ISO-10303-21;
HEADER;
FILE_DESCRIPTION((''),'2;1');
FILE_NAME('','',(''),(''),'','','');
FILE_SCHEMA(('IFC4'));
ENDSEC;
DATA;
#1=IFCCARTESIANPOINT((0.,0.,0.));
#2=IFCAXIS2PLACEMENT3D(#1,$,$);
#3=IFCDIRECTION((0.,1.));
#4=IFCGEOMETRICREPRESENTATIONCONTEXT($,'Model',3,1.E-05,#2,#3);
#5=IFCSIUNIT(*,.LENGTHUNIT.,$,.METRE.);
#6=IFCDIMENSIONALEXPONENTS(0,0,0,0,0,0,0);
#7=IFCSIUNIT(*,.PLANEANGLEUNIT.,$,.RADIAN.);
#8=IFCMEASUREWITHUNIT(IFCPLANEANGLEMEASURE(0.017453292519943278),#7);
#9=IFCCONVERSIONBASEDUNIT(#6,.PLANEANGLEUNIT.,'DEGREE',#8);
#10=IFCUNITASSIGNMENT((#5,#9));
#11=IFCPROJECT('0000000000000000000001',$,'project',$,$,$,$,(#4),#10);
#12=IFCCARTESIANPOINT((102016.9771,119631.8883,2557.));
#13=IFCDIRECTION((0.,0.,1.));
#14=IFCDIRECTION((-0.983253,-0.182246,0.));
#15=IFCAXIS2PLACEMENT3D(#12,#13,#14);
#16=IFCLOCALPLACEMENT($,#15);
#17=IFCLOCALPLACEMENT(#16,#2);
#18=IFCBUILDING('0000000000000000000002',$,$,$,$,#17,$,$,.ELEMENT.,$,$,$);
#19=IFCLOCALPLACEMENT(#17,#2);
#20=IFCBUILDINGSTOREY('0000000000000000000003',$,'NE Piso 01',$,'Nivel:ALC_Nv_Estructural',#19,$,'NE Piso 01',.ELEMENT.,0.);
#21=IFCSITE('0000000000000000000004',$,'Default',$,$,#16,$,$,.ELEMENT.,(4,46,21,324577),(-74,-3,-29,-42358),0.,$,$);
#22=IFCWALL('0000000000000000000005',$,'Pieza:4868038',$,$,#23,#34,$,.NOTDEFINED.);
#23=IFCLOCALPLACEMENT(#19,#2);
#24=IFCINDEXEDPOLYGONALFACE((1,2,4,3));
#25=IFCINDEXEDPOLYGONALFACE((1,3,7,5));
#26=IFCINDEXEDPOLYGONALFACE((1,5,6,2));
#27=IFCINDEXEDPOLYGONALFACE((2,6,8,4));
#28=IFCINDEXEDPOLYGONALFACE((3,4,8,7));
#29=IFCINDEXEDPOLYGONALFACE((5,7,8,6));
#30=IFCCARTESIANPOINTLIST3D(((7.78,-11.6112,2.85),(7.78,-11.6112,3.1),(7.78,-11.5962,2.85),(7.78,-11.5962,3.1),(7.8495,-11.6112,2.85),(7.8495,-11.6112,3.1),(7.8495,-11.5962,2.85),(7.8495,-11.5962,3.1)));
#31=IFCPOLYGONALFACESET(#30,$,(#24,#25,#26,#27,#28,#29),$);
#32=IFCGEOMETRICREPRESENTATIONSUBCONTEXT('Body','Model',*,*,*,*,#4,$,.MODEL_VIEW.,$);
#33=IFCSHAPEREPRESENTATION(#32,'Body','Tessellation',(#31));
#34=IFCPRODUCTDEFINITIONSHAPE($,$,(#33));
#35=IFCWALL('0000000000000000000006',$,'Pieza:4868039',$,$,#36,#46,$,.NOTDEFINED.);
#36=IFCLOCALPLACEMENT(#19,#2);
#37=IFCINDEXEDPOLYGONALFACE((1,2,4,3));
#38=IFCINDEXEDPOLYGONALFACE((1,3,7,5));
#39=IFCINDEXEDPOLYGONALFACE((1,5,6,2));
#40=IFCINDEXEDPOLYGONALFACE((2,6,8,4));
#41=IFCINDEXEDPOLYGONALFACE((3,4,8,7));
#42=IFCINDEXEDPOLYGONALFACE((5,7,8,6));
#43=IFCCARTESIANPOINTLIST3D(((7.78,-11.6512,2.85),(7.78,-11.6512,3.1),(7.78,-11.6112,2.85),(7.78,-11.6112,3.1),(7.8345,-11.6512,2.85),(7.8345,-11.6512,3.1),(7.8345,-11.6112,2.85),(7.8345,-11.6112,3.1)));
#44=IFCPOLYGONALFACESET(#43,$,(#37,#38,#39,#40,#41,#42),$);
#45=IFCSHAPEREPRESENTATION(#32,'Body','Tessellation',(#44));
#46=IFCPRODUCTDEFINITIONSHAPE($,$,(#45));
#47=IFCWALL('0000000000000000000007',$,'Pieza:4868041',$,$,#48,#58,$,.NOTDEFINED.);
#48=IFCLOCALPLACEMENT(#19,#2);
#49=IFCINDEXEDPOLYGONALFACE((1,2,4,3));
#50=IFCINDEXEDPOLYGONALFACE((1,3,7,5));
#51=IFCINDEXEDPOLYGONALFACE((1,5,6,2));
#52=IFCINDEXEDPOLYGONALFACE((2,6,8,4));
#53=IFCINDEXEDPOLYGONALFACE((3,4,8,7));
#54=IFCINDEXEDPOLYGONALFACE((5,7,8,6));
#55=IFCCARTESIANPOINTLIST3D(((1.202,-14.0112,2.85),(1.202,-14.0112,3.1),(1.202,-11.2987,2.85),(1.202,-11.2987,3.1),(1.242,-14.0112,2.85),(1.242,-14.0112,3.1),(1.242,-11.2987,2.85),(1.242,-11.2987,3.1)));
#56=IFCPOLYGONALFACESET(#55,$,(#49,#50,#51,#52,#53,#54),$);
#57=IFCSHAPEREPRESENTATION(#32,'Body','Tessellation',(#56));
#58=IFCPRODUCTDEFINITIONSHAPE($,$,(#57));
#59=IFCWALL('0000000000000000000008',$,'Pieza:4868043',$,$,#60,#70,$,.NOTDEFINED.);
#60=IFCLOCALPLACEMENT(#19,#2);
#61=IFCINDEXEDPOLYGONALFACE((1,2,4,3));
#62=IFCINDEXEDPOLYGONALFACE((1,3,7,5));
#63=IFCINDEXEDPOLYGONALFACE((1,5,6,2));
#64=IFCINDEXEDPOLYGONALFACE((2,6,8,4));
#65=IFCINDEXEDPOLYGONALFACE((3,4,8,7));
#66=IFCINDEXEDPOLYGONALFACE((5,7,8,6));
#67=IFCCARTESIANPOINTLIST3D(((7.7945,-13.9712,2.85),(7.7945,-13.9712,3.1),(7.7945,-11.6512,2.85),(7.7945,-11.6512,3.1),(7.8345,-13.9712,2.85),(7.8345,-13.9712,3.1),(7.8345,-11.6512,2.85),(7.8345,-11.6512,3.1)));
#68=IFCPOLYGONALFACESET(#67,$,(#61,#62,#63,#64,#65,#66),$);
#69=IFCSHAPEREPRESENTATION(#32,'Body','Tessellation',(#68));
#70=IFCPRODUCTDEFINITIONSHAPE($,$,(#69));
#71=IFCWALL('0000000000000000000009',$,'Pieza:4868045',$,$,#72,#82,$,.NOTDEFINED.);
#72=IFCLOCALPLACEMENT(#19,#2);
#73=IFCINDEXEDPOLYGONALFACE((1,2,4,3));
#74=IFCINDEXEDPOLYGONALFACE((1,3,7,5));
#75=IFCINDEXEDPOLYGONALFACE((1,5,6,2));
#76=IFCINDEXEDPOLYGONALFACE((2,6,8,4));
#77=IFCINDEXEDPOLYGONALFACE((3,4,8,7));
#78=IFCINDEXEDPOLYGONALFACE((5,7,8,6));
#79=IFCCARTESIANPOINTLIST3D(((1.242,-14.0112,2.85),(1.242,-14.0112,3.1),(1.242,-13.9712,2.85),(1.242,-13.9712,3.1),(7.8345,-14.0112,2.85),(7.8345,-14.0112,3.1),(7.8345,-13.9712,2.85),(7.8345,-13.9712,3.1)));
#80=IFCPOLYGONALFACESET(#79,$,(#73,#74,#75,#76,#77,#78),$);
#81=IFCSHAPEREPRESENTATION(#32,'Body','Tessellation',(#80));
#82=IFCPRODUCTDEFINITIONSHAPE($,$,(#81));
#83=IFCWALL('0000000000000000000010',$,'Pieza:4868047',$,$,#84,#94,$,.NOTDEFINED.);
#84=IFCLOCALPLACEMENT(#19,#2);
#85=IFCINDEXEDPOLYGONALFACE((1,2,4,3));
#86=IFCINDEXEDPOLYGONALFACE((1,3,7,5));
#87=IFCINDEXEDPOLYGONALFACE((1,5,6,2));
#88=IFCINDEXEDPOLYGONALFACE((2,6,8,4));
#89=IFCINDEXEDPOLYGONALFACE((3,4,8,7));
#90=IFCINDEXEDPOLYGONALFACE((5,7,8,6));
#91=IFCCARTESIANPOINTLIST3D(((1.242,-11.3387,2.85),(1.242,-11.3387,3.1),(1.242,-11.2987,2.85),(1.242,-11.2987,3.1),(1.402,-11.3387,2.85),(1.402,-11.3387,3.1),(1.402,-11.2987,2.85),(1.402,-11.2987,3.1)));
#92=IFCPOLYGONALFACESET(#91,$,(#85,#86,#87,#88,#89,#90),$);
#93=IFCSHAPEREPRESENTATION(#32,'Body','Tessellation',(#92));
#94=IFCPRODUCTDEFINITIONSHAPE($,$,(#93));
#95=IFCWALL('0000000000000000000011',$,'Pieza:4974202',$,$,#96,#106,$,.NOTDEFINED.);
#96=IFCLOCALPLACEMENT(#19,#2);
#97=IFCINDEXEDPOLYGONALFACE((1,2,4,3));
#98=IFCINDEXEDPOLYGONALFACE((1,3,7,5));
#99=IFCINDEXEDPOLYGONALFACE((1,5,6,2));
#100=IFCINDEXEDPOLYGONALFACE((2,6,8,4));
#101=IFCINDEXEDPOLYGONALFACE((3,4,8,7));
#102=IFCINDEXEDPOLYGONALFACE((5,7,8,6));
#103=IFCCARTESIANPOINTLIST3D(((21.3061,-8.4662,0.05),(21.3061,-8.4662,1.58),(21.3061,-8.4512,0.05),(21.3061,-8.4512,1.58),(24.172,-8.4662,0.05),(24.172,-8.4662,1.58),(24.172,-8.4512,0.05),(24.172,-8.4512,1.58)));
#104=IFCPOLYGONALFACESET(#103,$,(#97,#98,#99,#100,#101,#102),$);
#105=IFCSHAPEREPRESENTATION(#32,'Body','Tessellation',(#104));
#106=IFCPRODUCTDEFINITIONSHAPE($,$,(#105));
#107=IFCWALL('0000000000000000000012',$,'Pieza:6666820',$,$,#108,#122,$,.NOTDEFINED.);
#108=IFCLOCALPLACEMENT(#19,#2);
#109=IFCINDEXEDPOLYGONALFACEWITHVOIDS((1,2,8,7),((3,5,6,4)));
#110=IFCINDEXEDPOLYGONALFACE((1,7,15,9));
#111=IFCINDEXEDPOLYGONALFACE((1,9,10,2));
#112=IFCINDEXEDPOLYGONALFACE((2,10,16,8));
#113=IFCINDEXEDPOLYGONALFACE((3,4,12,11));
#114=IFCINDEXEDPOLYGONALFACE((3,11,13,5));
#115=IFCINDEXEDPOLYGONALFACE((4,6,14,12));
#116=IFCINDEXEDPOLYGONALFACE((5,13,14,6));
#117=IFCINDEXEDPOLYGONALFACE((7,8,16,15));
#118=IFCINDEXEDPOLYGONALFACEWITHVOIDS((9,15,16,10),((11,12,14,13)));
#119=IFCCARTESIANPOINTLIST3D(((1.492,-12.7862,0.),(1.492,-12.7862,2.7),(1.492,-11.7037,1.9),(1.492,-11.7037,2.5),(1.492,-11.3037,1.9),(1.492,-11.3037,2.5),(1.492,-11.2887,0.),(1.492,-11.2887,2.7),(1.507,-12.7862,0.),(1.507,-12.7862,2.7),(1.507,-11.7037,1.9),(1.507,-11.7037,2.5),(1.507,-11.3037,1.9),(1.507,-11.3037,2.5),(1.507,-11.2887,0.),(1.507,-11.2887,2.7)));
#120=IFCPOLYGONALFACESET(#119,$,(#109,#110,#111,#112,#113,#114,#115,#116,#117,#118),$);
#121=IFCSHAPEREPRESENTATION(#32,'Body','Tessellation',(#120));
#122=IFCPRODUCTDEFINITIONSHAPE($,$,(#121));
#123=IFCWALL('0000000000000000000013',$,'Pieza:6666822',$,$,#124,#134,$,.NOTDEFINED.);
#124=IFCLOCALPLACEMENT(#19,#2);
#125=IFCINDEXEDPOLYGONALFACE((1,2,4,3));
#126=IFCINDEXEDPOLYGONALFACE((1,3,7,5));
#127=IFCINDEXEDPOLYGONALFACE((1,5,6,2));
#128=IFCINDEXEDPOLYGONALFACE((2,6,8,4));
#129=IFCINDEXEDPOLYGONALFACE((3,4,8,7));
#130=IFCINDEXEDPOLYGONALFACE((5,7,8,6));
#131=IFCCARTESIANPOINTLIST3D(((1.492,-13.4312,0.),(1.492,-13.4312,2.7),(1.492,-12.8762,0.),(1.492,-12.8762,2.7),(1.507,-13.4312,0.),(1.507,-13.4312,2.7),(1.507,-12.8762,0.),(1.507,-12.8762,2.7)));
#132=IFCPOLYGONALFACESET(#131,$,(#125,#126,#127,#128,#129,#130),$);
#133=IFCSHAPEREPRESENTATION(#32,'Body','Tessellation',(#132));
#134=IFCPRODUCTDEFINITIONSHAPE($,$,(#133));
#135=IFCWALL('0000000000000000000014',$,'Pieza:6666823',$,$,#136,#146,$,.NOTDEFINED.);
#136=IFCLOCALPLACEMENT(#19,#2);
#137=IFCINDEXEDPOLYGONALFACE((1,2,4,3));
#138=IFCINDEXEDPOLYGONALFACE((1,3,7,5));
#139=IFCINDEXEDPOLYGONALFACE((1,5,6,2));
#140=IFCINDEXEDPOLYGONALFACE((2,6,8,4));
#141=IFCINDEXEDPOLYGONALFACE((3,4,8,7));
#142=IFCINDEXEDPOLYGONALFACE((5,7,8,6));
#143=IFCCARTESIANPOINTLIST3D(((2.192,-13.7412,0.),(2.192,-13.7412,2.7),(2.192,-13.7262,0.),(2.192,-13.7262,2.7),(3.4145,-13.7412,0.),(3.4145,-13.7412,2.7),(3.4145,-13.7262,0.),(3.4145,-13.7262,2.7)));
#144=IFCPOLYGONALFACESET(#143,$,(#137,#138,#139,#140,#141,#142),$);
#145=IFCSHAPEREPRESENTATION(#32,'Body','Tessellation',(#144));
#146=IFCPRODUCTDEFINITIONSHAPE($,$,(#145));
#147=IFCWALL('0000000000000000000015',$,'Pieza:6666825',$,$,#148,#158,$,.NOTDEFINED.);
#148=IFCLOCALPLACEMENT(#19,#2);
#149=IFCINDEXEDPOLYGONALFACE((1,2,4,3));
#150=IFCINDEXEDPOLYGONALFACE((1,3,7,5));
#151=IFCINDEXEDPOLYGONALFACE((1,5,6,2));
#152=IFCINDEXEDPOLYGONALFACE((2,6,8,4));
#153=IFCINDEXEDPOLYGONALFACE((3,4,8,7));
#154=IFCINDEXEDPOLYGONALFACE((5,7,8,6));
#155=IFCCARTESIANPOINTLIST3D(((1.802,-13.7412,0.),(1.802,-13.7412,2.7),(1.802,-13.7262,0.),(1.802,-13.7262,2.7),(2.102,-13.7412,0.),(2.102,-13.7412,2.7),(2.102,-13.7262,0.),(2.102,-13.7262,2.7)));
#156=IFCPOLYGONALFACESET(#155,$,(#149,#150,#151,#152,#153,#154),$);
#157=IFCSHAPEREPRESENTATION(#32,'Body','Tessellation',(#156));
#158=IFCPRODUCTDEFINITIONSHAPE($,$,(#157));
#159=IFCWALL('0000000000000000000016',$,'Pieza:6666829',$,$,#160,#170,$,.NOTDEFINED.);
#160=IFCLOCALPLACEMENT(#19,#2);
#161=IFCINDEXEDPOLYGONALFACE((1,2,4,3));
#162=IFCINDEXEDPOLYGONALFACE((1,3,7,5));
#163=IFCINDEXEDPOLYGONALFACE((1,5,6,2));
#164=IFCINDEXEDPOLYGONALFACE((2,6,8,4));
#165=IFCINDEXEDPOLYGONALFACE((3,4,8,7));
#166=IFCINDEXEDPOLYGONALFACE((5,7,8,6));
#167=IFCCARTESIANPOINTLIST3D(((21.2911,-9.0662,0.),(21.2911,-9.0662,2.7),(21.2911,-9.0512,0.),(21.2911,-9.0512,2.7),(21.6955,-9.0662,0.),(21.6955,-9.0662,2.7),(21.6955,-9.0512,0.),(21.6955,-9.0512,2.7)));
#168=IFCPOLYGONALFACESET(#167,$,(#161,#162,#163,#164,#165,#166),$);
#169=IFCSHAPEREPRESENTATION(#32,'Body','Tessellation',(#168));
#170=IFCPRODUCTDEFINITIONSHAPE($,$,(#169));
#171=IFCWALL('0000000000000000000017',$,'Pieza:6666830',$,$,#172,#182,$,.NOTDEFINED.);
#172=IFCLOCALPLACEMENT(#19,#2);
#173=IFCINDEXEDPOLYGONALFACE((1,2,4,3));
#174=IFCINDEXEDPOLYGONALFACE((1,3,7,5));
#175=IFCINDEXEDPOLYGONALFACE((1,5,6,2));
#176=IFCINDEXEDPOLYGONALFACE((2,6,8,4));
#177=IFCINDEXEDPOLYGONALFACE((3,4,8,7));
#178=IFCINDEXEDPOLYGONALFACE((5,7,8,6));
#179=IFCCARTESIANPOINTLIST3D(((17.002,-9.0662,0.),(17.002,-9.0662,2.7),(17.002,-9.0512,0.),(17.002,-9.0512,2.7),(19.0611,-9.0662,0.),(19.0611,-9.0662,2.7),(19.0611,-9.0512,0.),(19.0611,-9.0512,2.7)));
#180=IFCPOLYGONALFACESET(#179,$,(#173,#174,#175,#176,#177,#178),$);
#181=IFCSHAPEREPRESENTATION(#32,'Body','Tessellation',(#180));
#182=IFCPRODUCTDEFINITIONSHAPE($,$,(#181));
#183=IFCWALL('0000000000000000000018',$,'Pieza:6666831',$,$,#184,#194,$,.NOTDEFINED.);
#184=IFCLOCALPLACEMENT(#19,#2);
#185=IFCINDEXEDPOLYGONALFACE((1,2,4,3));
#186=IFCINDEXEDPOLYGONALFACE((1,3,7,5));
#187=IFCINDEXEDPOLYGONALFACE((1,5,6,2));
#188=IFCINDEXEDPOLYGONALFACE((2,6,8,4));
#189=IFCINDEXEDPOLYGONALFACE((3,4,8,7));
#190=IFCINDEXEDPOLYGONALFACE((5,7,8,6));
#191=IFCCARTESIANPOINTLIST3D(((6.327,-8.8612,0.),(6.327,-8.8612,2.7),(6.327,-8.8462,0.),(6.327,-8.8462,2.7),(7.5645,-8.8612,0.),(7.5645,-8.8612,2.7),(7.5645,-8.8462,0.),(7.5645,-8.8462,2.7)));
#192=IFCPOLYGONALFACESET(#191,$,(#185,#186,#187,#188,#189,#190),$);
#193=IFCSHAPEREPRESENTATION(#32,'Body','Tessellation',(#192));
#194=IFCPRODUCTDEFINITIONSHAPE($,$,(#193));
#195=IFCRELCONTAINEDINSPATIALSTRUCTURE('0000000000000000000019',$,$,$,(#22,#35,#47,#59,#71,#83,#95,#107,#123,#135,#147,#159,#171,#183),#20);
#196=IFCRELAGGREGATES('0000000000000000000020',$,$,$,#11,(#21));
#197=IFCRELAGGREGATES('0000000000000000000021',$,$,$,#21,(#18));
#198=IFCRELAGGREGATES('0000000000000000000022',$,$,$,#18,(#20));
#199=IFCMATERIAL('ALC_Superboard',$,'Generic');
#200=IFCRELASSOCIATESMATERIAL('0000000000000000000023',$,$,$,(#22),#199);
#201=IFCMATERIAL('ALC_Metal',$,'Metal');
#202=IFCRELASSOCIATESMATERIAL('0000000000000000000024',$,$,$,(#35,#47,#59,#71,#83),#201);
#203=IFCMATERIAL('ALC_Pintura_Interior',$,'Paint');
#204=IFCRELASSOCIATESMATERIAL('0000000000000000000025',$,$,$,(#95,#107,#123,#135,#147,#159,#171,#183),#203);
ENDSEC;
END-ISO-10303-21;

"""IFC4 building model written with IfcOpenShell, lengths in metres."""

from ifc_helpers import new_model, entity, si_unit, converted_unit, direction, frame, frame_2d, origin, origin_2d_with_axis, place, context, subcontext, project, spatial, rectangle, extrude, boolean, material, element, save


model = new_model("IFC4")

# Units and contexts
model_context = context("Model", 3, precision=1e-05, world=origin(), true_north=direction((0.0, 1.0)))
body_context = subcontext(model_context, "Body", "Model", "MODEL_VIEW")
ifc_project = project(units=[si_unit("LENGTHUNIT", "METRE"), converted_unit("PLANEANGLEUNIT", "DEGREE", entity("IfcPlaneAngleMeasure", 0.017453292519943278), si_unit("PLANEANGLEUNIT", "RADIAN"), dimensions=[0, 0, 0, 0, 0, 0, 0])], contexts=[model_context])

# Site, building, storey
site_placement = place(None, frame((102016.9771, 119631.8883, 2557.0), z_axis=(0.0, 0.0, 1.0), x_axis=(-0.983253, -0.182246, 0.0)))
site = spatial("IfcSite", under=ifc_project, at=site_placement, Name="Default", CompositionType="ELEMENT", RefLatitude=(4, 46, 21, 324577), RefLongitude=(-74, -3, -29, -42358), RefElevation=0.0)
building_placement = place(site_placement, origin())
building = spatial("IfcBuilding", under=site, at=building_placement, CompositionType="ELEMENT")
storey_placement = place(building_placement, origin())
storey = spatial("IfcBuildingStorey", under=building, at=storey_placement, Name="NE Piso 01", ObjectType="Nivel:ALC_Nv_Estructural", LongName="NE Piso 01", CompositionType="ELEMENT", Elevation=0.0)

# Walls
ifc_material_1 = material(Name="ALC_Superboard", Category="Generic")
wall_1_placement = place(storey_placement, frame((0.0, 0.0, 2.85)))
element("IfcWall", 1, at=wall_1_placement, inside=storey, material=ifc_material_1, Name="Pieza:4868038", PredefinedType="NOTDEFINED", context=body_context, shape_type="SweptSolid", body=[
    extrude(rectangle(XDim=0.015, YDim=0.0695, at=frame_2d((0.0, 0.0), x_axis=(1.0, 0.0))), frame((7.8148, -11.6037, 0.0), z_axis=(0.0, 0.0, 1.0), x_axis=(0.0, -1.0, 0.0)), (0.0, 0.0, 1.0), 0.25),
])
ifc_material_2 = material(Name="ALC_Metal", Category="Metal")
wall_2_placement = place(storey_placement, frame((0.0, 0.0, 2.85)))
element("IfcWall", 2, at=wall_2_placement, inside=storey, material=ifc_material_2, Name="Pieza:4868039", PredefinedType="NOTDEFINED", context=body_context, shape_type="SweptSolid", body=[
    extrude(rectangle(XDim=0.04, YDim=0.0545, at=frame_2d((0.0, 0.0), x_axis=(1.0, 0.0))), frame((7.8073, -11.6312, 0.0), z_axis=(0.0, 0.0, 1.0), x_axis=(0.0, -1.0, 0.0)), (0.0, 0.0, 1.0), 0.25),
])
wall_3_placement = place(storey_placement, frame((0.0, 0.0, 2.85)))
element("IfcWall", 3, at=wall_3_placement, inside=storey, material=ifc_material_2, Name="Pieza:4868041", PredefinedType="NOTDEFINED", context=body_context, shape_type="SweptSolid", body=[
    extrude(rectangle(XDim=2.7125, YDim=0.04, at=frame_2d((0.0, 0.0), x_axis=(1.0, 0.0))), frame((1.222, -12.6549, 0.0), z_axis=(0.0, 0.0, 1.0), x_axis=(0.0, -1.0, 0.0)), (0.0, 0.0, 1.0), 0.25),
])
wall_4_placement = place(storey_placement, frame((0.0, 0.0, 2.85)))
element("IfcWall", 4, at=wall_4_placement, inside=storey, material=ifc_material_2, Name="Pieza:4868043", PredefinedType="NOTDEFINED", context=body_context, shape_type="SweptSolid", body=[
    extrude(rectangle(XDim=2.32, YDim=0.04, at=origin_2d_with_axis()), frame((7.8145, -12.8112, 0.0), z_axis=(0.0, 0.0, 1.0), x_axis=(0.0, -1.0, 0.0)), (0.0, 0.0, 1.0), 0.25),
])
wall_5_placement = place(storey_placement, frame((0.0, 0.0, 2.85)))
element("IfcWall", 5, at=wall_5_placement, inside=storey, material=ifc_material_2, Name="Pieza:4868045", PredefinedType="NOTDEFINED", context=body_context, shape_type="SweptSolid", body=[
    extrude(rectangle(XDim=0.04, YDim=6.5925, at=frame_2d((0.0, 0.0), x_axis=(1.0, 0.0))), frame((4.5383, -13.9912, 0.0), z_axis=(0.0, 0.0, 1.0), x_axis=(0.0, -1.0, 0.0)), (0.0, 0.0, 1.0), 0.25),
])
wall_6_placement = place(storey_placement, frame((0.0, 0.0, 2.85)))
element("IfcWall", 6, at=wall_6_placement, inside=storey, material=ifc_material_2, Name="Pieza:4868047", PredefinedType="NOTDEFINED", context=body_context, shape_type="SweptSolid", body=[
    extrude(rectangle(XDim=0.04, YDim=0.16, at=frame_2d((0.0, 0.0), x_axis=(1.0, 0.0))), frame((1.322, -11.3187, 0.0), z_axis=(0.0, 0.0, 1.0), x_axis=(0.0, -1.0, 0.0)), (0.0, 0.0, 1.0), 0.25),
])
ifc_material_3 = material(Name="ALC_Pintura_Interior", Category="Paint")
wall_7_placement = place(storey_placement, frame((0.0, 0.0, 0.05)))
element("IfcWall", 7, at=wall_7_placement, inside=storey, material=ifc_material_3, Name="Pieza:4974202", PredefinedType="NOTDEFINED", context=body_context, shape_type="SweptSolid", body=[
    extrude(rectangle(XDim=0.015, YDim=2.8659, at=frame_2d((0.0, 0.0), x_axis=(1.0, 0.0))), frame((22.7391, -8.4587, 0.0), z_axis=(0.0, 0.0, 1.0), x_axis=(0.0, -1.0, 0.0)), (0.0, 0.0, 1.0), 1.53),
])
wall_8_placement = place(storey_placement, origin())
element("IfcWall", 8, at=wall_8_placement, inside=storey, material=ifc_material_3, Name="Pieza:6666820", PredefinedType="NOTDEFINED", context=body_context, shape_type="SweptSolid", body=[
    boolean("DIFFERENCE", extrude(rectangle(XDim=0.015, YDim=1.4975, at=frame_2d((0.0, 0.0), x_axis=(1.0, 0.0))), frame((1.4995, -12.0374, 0.0)), (0.0, 0.0, 1.0), 2.7), extrude(rectangle(XDim=0.6, YDim=0.4, at=frame_2d((0.0, 0.0), x_axis=(0.0, 1.0))), frame((1.492, -11.5037, 2.2), z_axis=(-1.0, 0.0, 0.0), x_axis=(0.0, 1.0, 0.0)), (0.0, 0.0, -1.0), 0.015)),
])
wall_9_placement = place(storey_placement, origin())
element("IfcWall", 9, at=wall_9_placement, inside=storey, material=ifc_material_3, Name="Pieza:6666822", PredefinedType="NOTDEFINED", context=body_context, shape_type="SweptSolid", body=[
    extrude(rectangle(XDim=0.555, YDim=0.015, at=frame_2d((0.0, 0.0), x_axis=(1.0, 0.0))), frame((1.4995, -13.1537, 0.0), z_axis=(0.0, 0.0, 1.0), x_axis=(0.0, -1.0, 0.0)), (0.0, 0.0, 1.0), 2.7),
])
wall_10_placement = place(storey_placement, origin())
element("IfcWall", 10, at=wall_10_placement, inside=storey, material=ifc_material_3, Name="Pieza:6666823", PredefinedType="NOTDEFINED", context=body_context, shape_type="SweptSolid", body=[
    extrude(rectangle(XDim=0.015, YDim=1.2225, at=frame_2d((0.0, 0.0), x_axis=(1.0, 0.0))), frame((2.8033, -13.7337, 0.0), z_axis=(0.0, 0.0, 1.0), x_axis=(0.0, -1.0, 0.0)), (0.0, 0.0, 1.0), 2.7),
])
wall_11_placement = place(storey_placement, origin())
element("IfcWall", 11, at=wall_11_placement, inside=storey, material=ifc_material_3, Name="Pieza:6666825", PredefinedType="NOTDEFINED", context=body_context, shape_type="SweptSolid", body=[
    extrude(rectangle(XDim=0.015, YDim=0.3, at=origin_2d_with_axis()), frame((1.952, -13.7337, 0.0), z_axis=(0.0, 0.0, 1.0), x_axis=(0.0, -1.0, 0.0)), (0.0, 0.0, 1.0), 2.7),
])
wall_12_placement = place(storey_placement, origin())
element("IfcWall", 12, at=wall_12_placement, inside=storey, material=ifc_material_3, Name="Pieza:6666829", PredefinedType="NOTDEFINED", context=body_context, shape_type="SweptSolid", body=[
    extrude(rectangle(XDim=0.015, YDim=0.4044, at=frame_2d((0.0, 0.0), x_axis=(1.0, 0.0))), frame((21.4933, -9.0587, 0.0), z_axis=(0.0, 0.0, 1.0), x_axis=(0.0, -1.0, 0.0)), (0.0, 0.0, 1.0), 2.7),
])
wall_13_placement = place(storey_placement, origin())
element("IfcWall", 13, at=wall_13_placement, inside=storey, material=ifc_material_3, Name="Pieza:6666830", PredefinedType="NOTDEFINED", context=body_context, shape_type="SweptSolid", body=[
    extrude(rectangle(XDim=0.015, YDim=2.0591, at=frame_2d((0.0, 0.0), x_axis=(1.0, 0.0))), frame((18.0316, -9.0587, 0.0), z_axis=(0.0, 0.0, 1.0), x_axis=(0.0, -1.0, 0.0)), (0.0, 0.0, 1.0), 2.7),
])
wall_14_placement = place(storey_placement, origin())
element("IfcWall", 14, at=wall_14_placement, inside=storey, material=ifc_material_3, Name="Pieza:6666831", PredefinedType="NOTDEFINED", context=body_context, shape_type="SweptSolid", body=[
    extrude(rectangle(XDim=0.015, YDim=1.2375, at=frame_2d((0.0, 0.0), x_axis=(1.0, 0.0))), frame((6.9458, -8.8537, 0.0), z_axis=(0.0, 0.0, 1.0), x_axis=(0.0, -1.0, 0.0)), (0.0, 0.0, 1.0), 2.7),
])

save(model, "model.ifc")
